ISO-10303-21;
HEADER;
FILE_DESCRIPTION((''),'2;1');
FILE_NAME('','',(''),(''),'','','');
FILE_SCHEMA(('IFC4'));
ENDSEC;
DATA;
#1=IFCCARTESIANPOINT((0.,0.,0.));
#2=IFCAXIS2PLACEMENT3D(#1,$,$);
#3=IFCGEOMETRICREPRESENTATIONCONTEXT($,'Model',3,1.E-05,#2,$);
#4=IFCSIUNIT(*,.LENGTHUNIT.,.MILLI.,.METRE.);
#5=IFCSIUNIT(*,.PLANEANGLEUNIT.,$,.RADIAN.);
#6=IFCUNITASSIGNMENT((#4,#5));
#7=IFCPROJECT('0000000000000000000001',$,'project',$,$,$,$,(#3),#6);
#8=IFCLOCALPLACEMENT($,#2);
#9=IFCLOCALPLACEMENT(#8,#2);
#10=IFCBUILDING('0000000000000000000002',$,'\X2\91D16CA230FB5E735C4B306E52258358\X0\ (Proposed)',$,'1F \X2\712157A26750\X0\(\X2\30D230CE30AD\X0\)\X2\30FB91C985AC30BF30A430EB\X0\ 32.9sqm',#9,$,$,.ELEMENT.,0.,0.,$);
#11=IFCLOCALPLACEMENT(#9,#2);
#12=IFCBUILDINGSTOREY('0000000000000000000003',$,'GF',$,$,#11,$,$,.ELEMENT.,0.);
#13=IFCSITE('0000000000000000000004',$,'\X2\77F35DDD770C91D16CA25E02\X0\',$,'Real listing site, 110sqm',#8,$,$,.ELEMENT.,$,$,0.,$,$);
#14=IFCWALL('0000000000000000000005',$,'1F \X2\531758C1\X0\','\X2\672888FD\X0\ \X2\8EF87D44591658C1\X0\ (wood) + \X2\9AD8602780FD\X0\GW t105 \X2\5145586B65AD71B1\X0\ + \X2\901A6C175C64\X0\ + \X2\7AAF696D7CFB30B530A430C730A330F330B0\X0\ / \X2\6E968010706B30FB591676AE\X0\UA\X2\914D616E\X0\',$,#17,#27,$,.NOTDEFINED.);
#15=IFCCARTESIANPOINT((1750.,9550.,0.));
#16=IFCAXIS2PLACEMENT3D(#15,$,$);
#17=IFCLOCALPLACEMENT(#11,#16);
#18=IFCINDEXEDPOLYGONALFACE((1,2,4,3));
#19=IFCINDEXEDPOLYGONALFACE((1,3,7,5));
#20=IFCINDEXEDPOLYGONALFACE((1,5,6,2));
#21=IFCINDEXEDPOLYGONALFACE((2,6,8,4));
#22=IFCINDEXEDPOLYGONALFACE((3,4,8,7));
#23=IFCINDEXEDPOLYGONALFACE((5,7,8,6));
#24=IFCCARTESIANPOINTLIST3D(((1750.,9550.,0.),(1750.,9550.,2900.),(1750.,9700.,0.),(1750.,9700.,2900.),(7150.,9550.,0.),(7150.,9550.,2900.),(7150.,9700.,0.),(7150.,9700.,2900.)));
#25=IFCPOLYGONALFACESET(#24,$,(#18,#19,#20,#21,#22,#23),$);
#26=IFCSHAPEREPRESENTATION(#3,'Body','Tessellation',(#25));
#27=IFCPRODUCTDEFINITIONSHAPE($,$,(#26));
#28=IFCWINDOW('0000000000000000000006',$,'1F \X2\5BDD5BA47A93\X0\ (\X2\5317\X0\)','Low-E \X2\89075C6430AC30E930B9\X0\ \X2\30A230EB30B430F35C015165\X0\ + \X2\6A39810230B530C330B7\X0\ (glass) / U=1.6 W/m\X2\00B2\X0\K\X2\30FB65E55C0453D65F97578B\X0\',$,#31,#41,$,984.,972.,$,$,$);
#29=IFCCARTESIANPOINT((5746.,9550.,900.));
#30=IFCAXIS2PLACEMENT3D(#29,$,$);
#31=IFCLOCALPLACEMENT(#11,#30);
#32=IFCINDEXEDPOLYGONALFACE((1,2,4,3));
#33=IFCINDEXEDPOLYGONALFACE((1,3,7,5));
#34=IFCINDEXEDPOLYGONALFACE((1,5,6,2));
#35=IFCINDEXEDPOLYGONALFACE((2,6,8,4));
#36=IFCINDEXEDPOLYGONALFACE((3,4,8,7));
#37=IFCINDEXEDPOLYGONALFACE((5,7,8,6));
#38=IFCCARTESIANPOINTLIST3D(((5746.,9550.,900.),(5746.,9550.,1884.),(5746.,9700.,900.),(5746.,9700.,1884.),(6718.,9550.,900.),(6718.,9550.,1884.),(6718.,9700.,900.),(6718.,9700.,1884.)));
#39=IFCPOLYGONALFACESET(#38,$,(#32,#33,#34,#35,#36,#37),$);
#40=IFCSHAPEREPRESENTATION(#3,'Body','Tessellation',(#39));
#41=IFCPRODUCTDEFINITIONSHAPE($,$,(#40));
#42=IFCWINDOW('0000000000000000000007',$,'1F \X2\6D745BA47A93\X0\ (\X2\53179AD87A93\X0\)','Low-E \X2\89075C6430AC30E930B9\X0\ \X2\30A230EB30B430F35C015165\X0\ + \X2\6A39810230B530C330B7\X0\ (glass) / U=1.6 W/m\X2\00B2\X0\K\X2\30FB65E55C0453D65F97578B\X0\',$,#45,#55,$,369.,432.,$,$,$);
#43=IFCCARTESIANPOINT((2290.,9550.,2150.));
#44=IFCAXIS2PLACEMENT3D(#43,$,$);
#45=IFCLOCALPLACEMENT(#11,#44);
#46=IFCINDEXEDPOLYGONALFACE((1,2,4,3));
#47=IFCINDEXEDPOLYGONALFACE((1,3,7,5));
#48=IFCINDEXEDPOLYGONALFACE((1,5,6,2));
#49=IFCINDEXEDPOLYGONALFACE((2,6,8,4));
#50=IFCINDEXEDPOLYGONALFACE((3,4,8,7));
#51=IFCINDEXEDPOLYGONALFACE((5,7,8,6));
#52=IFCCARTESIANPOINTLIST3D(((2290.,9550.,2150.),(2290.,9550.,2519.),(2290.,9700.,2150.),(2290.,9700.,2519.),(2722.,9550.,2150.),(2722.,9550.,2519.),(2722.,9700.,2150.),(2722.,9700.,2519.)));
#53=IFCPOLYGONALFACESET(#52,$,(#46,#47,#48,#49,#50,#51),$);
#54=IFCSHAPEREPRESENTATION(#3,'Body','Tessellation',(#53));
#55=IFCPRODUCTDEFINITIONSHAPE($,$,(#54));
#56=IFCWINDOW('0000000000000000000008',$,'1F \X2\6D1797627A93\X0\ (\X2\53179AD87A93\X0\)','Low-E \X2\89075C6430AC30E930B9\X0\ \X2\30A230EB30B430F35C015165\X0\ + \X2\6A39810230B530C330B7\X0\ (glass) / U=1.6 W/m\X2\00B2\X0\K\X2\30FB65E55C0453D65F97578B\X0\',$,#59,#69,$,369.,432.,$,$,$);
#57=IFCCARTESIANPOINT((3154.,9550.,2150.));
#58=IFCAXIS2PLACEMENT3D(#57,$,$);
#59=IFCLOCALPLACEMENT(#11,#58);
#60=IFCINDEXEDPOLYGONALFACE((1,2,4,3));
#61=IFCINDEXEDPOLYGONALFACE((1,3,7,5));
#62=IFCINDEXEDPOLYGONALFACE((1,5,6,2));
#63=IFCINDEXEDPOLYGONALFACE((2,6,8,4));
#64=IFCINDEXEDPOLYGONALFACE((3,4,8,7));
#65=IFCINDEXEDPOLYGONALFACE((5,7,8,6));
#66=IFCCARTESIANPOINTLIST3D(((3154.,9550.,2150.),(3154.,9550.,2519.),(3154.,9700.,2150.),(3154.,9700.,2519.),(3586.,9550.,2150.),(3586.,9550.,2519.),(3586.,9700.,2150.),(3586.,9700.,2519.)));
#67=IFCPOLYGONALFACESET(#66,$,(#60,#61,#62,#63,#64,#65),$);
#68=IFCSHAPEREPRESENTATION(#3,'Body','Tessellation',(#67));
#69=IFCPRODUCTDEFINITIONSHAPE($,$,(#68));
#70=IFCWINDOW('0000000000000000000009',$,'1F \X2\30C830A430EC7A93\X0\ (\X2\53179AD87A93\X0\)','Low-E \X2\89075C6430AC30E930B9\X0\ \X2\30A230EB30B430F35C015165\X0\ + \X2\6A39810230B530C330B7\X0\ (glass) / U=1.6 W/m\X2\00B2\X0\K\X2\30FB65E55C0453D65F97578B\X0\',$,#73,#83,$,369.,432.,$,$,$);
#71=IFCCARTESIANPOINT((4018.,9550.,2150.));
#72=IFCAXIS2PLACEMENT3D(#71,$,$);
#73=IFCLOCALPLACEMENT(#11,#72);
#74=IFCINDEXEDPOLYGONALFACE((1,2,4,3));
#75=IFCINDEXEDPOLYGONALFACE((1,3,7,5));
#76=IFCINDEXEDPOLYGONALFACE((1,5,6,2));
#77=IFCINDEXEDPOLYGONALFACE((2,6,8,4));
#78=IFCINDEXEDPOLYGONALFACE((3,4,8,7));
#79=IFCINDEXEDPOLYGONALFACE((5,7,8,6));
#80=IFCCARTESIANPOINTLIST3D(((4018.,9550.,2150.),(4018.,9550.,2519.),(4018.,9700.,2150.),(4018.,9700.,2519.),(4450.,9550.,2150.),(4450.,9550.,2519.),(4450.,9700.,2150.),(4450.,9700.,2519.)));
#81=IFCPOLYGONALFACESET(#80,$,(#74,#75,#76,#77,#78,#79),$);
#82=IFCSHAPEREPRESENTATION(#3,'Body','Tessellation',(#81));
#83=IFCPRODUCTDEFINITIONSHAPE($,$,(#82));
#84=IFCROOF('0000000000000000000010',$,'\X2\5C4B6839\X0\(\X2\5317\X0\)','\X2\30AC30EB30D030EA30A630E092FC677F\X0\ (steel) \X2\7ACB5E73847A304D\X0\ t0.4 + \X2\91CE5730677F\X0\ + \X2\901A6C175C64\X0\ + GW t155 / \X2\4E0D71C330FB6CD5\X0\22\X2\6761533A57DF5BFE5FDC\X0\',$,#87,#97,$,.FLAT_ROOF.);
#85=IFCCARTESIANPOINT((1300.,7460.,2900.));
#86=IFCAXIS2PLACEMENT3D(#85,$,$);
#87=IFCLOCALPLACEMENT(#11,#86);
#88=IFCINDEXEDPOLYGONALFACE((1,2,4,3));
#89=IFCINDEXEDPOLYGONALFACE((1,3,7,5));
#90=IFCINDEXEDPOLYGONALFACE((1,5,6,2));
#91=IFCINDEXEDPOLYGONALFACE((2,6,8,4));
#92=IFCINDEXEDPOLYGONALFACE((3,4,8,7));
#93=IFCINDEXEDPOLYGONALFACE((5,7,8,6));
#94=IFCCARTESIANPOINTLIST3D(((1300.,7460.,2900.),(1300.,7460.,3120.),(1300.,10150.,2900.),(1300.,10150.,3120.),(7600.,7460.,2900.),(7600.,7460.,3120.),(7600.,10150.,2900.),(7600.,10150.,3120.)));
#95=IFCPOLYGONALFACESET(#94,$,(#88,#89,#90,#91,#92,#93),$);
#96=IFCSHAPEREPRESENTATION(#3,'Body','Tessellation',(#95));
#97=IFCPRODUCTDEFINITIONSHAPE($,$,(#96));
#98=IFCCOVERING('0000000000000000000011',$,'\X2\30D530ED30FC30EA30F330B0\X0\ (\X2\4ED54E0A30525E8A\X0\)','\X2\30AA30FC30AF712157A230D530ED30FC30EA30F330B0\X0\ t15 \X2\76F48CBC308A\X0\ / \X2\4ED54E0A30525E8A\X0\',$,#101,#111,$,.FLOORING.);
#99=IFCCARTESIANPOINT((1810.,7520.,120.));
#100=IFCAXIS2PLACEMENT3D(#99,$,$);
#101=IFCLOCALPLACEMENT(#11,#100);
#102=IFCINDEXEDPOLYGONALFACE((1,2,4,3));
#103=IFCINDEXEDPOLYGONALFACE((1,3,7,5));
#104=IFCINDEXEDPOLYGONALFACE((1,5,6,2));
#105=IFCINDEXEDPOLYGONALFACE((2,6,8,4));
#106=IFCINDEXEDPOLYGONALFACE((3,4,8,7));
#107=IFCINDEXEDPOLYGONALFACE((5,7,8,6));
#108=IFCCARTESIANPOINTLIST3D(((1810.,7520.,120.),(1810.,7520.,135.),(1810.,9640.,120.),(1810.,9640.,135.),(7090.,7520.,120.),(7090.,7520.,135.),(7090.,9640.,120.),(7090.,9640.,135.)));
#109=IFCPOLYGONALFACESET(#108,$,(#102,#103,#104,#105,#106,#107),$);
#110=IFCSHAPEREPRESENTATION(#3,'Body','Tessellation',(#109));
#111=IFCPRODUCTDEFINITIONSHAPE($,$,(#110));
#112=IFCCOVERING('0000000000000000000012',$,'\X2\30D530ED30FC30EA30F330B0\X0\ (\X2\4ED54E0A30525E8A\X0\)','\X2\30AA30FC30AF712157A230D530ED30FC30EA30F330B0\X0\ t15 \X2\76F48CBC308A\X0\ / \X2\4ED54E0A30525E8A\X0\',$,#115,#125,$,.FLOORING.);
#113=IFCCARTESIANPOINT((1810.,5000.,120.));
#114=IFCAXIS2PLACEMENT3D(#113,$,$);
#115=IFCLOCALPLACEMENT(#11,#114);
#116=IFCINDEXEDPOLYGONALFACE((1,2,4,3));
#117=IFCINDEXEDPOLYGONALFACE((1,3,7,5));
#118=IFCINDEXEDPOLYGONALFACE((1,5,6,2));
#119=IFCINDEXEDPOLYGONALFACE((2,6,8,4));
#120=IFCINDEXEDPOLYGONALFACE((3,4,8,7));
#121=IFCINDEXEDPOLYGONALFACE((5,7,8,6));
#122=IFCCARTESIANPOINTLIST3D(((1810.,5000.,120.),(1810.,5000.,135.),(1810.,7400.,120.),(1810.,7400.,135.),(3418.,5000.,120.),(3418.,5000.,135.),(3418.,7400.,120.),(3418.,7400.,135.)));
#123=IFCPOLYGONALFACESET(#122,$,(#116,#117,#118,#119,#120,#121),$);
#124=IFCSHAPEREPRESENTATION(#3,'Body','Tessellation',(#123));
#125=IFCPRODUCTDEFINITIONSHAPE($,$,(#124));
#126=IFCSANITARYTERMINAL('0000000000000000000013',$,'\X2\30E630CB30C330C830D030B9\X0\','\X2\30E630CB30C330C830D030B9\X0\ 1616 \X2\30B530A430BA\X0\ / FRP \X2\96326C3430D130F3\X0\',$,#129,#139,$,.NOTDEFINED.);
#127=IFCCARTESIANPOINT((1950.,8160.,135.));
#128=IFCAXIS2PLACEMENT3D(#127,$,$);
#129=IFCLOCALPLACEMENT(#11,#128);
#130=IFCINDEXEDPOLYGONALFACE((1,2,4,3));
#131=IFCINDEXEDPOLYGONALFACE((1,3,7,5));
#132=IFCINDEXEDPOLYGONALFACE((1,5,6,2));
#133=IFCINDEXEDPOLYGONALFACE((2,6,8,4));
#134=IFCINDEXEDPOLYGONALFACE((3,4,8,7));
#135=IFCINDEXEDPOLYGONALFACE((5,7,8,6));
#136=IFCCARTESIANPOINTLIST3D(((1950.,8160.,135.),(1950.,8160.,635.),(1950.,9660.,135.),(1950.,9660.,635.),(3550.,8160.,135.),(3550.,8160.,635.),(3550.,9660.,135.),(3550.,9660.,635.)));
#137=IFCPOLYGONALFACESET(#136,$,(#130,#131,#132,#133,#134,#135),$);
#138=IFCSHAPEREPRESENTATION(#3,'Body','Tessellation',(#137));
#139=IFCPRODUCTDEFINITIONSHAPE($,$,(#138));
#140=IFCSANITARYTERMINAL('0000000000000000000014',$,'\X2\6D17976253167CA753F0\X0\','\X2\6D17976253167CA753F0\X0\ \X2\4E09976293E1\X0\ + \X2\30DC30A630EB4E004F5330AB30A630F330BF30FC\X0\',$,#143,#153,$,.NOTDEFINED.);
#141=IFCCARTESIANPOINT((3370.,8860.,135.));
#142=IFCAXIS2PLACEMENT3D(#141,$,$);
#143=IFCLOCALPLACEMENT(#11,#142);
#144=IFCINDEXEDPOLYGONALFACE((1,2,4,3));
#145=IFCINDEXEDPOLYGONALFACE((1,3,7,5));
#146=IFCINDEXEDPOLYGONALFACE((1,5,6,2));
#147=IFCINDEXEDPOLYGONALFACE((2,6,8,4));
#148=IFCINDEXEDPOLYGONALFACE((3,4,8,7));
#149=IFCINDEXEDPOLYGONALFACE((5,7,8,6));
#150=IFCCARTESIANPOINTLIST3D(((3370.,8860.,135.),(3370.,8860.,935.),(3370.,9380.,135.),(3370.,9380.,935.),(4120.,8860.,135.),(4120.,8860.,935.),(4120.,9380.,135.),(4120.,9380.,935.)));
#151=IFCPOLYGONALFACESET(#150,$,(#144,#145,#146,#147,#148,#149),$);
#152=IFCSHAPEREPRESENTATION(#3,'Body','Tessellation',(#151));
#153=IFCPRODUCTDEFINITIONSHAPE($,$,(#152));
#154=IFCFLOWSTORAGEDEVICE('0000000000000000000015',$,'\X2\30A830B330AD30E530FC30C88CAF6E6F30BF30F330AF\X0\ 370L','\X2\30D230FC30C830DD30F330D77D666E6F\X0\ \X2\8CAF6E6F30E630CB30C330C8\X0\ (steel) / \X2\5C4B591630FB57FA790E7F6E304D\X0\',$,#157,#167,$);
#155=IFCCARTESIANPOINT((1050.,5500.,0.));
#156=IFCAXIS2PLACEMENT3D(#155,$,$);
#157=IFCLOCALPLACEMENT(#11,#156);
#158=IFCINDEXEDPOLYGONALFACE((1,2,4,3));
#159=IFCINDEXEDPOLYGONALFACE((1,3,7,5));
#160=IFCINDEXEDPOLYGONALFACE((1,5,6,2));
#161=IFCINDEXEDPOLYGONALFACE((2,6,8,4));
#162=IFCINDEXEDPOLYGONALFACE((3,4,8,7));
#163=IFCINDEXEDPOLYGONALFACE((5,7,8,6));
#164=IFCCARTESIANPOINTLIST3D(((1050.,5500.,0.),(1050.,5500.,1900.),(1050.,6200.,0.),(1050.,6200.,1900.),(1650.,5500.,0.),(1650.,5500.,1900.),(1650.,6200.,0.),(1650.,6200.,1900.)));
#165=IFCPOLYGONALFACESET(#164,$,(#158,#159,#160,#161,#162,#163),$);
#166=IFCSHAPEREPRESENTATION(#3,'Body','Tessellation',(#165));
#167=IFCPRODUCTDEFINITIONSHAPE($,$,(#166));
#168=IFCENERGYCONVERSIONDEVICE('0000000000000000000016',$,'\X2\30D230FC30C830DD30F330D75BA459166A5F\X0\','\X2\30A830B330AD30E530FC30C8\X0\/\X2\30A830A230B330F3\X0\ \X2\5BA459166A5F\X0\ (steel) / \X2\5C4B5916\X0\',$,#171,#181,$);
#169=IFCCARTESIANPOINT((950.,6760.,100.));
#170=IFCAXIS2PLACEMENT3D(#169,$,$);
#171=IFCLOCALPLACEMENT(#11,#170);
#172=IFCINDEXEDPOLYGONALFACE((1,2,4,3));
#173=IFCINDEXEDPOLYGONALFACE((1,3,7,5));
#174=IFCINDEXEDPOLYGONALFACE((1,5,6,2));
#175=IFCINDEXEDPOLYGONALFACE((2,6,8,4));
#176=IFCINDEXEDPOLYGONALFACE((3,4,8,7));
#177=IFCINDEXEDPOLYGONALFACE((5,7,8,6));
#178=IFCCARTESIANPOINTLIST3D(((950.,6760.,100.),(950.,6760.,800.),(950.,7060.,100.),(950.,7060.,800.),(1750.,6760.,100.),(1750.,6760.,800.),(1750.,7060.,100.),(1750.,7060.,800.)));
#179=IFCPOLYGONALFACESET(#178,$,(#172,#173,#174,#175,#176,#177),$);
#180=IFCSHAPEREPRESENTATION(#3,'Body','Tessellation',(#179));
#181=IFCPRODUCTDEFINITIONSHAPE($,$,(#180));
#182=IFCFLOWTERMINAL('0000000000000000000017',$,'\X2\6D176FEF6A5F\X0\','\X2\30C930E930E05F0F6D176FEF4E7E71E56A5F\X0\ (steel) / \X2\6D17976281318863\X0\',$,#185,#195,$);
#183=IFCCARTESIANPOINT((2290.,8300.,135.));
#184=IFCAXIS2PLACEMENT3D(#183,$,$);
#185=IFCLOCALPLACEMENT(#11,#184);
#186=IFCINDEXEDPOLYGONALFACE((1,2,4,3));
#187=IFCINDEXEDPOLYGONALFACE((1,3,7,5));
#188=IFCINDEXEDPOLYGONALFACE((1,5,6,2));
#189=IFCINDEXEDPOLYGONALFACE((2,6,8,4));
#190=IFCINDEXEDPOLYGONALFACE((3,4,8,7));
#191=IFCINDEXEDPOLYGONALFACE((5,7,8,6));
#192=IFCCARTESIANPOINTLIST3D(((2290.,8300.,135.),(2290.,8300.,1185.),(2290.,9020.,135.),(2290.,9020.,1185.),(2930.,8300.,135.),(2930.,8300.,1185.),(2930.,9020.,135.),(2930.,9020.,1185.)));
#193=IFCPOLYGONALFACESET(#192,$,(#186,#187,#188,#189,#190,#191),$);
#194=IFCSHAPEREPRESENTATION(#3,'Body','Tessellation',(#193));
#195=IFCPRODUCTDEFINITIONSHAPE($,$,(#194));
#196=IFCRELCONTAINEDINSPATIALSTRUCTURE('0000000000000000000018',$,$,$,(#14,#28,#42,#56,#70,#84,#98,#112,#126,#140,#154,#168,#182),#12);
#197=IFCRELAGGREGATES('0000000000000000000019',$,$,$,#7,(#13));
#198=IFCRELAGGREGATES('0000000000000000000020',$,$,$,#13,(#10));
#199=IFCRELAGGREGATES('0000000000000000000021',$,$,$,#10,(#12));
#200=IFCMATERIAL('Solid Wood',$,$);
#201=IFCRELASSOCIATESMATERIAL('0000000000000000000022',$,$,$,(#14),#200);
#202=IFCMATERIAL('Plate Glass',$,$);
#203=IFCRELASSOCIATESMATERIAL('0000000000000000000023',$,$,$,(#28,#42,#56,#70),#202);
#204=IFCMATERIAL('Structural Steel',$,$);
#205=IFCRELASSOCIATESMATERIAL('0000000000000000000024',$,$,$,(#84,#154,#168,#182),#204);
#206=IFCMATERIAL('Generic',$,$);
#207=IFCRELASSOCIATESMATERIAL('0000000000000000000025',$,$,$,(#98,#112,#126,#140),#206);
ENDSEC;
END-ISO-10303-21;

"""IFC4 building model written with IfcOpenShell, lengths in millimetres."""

from ifc_helpers import new_model, si_unit, frame, frame_2d, origin, place, context, project, spatial, rectangle, extrude, material, element, fill, save


model = new_model("IFC4")

# Units and contexts
model_context = context("Model", 3, precision=1e-05, world=origin())
ifc_project = project(units=[si_unit("LENGTHUNIT", "METRE", prefix="MILLI"), si_unit("PLANEANGLEUNIT", "RADIAN")], contexts=[model_context])

# Site, building, storey
site_placement = place(None, origin())
site = spatial("IfcSite", under=ifc_project, at=site_placement, Name="石川県金沢市", ObjectType="Real listing site, 110sqm", CompositionType="ELEMENT", RefElevation=0.0)
building_placement = place(site_placement, origin())
building = spatial("IfcBuilding", under=site, at=building_placement, Name="金沢・平屋の別荘 (Proposed)", ObjectType="1F 無垢材(ヒノキ)・釉薬タイル 32.9sqm", CompositionType="ELEMENT", ElevationOfRefHeight=0.0, ElevationOfTerrain=0.0)
storey_placement = place(building_placement, origin())
storey = spatial("IfcBuildingStorey", under=building, at=storey_placement, Name="GF", CompositionType="ELEMENT", Elevation=0.0)

# Shared definitions
ifc_material_1 = material(Name="Solid Wood")

# Wall, openings, windows
wall_1_placement = place(storey_placement, frame((1750.0, 9550.0, 0.0)))
wall_1 = element("IfcWall", 1, at=wall_1_placement, inside=storey, material=ifc_material_1, Name="1F 北壁", Description="木製 軸組外壁 (wood) + 高性能GW t105 充填断熱 + 通気層 + 窯業系サイディング / 準耐火・外皮UA配慮", PredefinedType="NOTDEFINED", context=model_context, shape_type="SweptSolid", body=[
    extrude(rectangle(XDim=5400.0, YDim=150.0, at=frame_2d((2700.0, 75.0))), frame((1750.0, 9550.0, 0.0)), (0.0, 0.0, 1.0), 2900.0),
])
opening_1_placement = place(storey_placement, frame((5746.0, 9550.0, 900.0)))
opening_1 = element("IfcOpeningElement", 2, at=opening_1_placement, cuts=wall_1, PredefinedType="NOTDEFINED", context=model_context, shape_type="SweptSolid", body=[
    extrude(rectangle(XDim=972.0, YDim=150.0, at=frame_2d((486.0, 75.0))), frame((5746.0, 9550.0, 900.0)), (0.0, 0.0, 1.0), 984.0),
])
opening_2_placement = place(storey_placement, frame((2290.0, 9550.0, 2150.0)))
opening_2 = element("IfcOpeningElement", 3, at=opening_2_placement, cuts=wall_1, PredefinedType="NOTDEFINED", context=model_context, shape_type="SweptSolid", body=[
    extrude(rectangle(XDim=432.0, YDim=150.0, at=frame_2d((216.0, 75.0))), frame((2290.0, 9550.0, 2150.0)), (0.0, 0.0, 1.0), 369.0),
])
opening_3_placement = place(storey_placement, frame((3154.0, 9550.0, 2150.0)))
opening_3 = element("IfcOpeningElement", 4, at=opening_3_placement, cuts=wall_1, PredefinedType="NOTDEFINED", context=model_context, shape_type="SweptSolid", body=[
    extrude(rectangle(XDim=432.0, YDim=150.0, at=frame_2d((216.0, 75.0))), frame((3154.0, 9550.0, 2150.0)), (0.0, 0.0, 1.0), 369.0),
])
opening_4_placement = place(storey_placement, frame((4018.0, 9550.0, 2150.0)))
opening_4 = element("IfcOpeningElement", 5, at=opening_4_placement, cuts=wall_1, PredefinedType="NOTDEFINED", context=model_context, shape_type="SweptSolid", body=[
    extrude(rectangle(XDim=432.0, YDim=150.0, at=frame_2d((216.0, 75.0))), frame((4018.0, 9550.0, 2150.0)), (0.0, 0.0, 1.0), 369.0),
])
ifc_material_2 = material(Name="Plate Glass")
window_1_placement = place(storey_placement, frame((5746.0, 9550.0, 900.0)))
window_1 = element("IfcWindow", 6, at=window_1_placement, inside=storey, material=ifc_material_2, Name="1F 寝室窓 (北)", Description="Low-E 複層ガラス アルゴン封入 + 樹脂サッシ (glass) / U=1.6 W/m²K・日射取得型", OverallHeight=984.0, OverallWidth=972.0, context=model_context, shape_type="SweptSolid", body=[
    extrude(rectangle(XDim=972.0, YDim=150.0, at=frame_2d((486.0, 75.0))), frame((5746.0, 9550.0, 900.0)), (0.0, 0.0, 1.0), 984.0),
])
fill(opening_1, window_1)
window_2_placement = place(storey_placement, frame((2290.0, 9550.0, 2150.0)))
window_2 = element("IfcWindow", 7, at=window_2_placement, inside=storey, material=ifc_material_2, Name="1F 浴室窓 (北高窓)", Description="Low-E 複層ガラス アルゴン封入 + 樹脂サッシ (glass) / U=1.6 W/m²K・日射取得型", OverallHeight=369.0, OverallWidth=432.0, context=model_context, shape_type="SweptSolid", body=[
    extrude(rectangle(XDim=432.0, YDim=150.0, at=frame_2d((216.0, 75.0))), frame((2290.0, 9550.0, 2150.0)), (0.0, 0.0, 1.0), 369.0),
])
fill(opening_2, window_2)
window_3_placement = place(storey_placement, frame((3154.0, 9550.0, 2150.0)))
window_3 = element("IfcWindow", 8, at=window_3_placement, inside=storey, material=ifc_material_2, Name="1F 洗面窓 (北高窓)", Description="Low-E 複層ガラス アルゴン封入 + 樹脂サッシ (glass) / U=1.6 W/m²K・日射取得型", OverallHeight=369.0, OverallWidth=432.0, context=model_context, shape_type="SweptSolid", body=[
    extrude(rectangle(XDim=432.0, YDim=150.0, at=frame_2d((216.0, 75.0))), frame((3154.0, 9550.0, 2150.0)), (0.0, 0.0, 1.0), 369.0),
])
fill(opening_3, window_3)
window_4_placement = place(storey_placement, frame((4018.0, 9550.0, 2150.0)))
window_4 = element("IfcWindow", 9, at=window_4_placement, inside=storey, material=ifc_material_2, Name="1F トイレ窓 (北高窓)", Description="Low-E 複層ガラス アルゴン封入 + 樹脂サッシ (glass) / U=1.6 W/m²K・日射取得型", OverallHeight=369.0, OverallWidth=432.0, context=model_context, shape_type="SweptSolid", body=[
    extrude(rectangle(XDim=432.0, YDim=150.0, at=frame_2d((216.0, 75.0))), frame((4018.0, 9550.0, 2150.0)), (0.0, 0.0, 1.0), 369.0),
])
fill(opening_4, window_4)

# Roof
ifc_material_3 = material(Name="Structural Steel")
roof_placement = place(storey_placement, frame((1300.0, 7460.0, 2900.0)))
element("IfcRoof", 10, at=roof_placement, inside=storey, material=ifc_material_3, Name="屋根(北)", Description="ガルバリウム鋼板 (steel) 立平葺き t0.4 + 野地板 + 通気層 + GW t155 / 不燃・法22条区域対応", PredefinedType="FLAT_ROOF", context=model_context, shape_type="SweptSolid", body=[
    extrude(rectangle(XDim=6300.0, YDim=2690.0, at=frame_2d((3150.0, 1345.0))), frame((1300.0, 7460.0, 2900.0)), (0.0, 0.0, 1.0), 220.0),
])

# Coverings
ifc_material_4 = material(Name="Generic")
covering_1_placement = place(storey_placement, frame((1810.0, 7520.0, 120.0)))
element("IfcCovering", 11, at=covering_1_placement, inside=storey, material=ifc_material_4, Name="フローリング (仕上げ床)", Description="オーク無垢フローリング t15 直貼り / 仕上げ床", PredefinedType="FLOORING", context=model_context, shape_type="SweptSolid", body=[
    extrude(rectangle(XDim=5280.0, YDim=2120.0, at=frame_2d((2640.0, 1060.0))), frame((1810.0, 7520.0, 120.0)), (0.0, 0.0, 1.0), 15.0),
])
covering_2_placement = place(storey_placement, frame((1810.0, 5000.0, 120.0)))
element("IfcCovering", 12, at=covering_2_placement, inside=storey, material=ifc_material_4, Name="フローリング (仕上げ床)", Description="オーク無垢フローリング t15 直貼り / 仕上げ床", PredefinedType="FLOORING", context=model_context, shape_type="SweptSolid", body=[
    extrude(rectangle(XDim=1608.0, YDim=2400.0, at=frame_2d((804.0, 1200.0))), frame((1810.0, 5000.0, 120.0)), (0.0, 0.0, 1.0), 15.0),
])

# Sanitary terminals
sanitary_terminal_1_placement = place(storey_placement, frame((1950.0, 8160.0, 135.0)))
element("IfcSanitaryTerminal", 13, at=sanitary_terminal_1_placement, inside=storey, material=ifc_material_4, Name="ユニットバス", Description="ユニットバス 1616 サイズ / FRP 防水パン", PredefinedType="NOTDEFINED", context=model_context, shape_type="SweptSolid", body=[
    extrude(rectangle(XDim=1600.0, YDim=1500.0, at=frame_2d((800.0, 750.0))), frame((1950.0, 8160.0, 135.0)), (0.0, 0.0, 1.0), 500.0),
])
sanitary_terminal_2_placement = place(storey_placement, frame((3370.0, 8860.0, 135.0)))
element("IfcSanitaryTerminal", 14, at=sanitary_terminal_2_placement, inside=storey, material=ifc_material_4, Name="洗面化粧台", Description="洗面化粧台 三面鏡 + ボウル一体カウンター", PredefinedType="NOTDEFINED", context=model_context, shape_type="SweptSolid", body=[
    extrude(rectangle(XDim=750.0, YDim=520.0, at=frame_2d((375.0, 260.0))), frame((3370.0, 8860.0, 135.0)), (0.0, 0.0, 1.0), 800.0),
])

# Flow storage device
flow_storage_device_placement = place(storey_placement, frame((1050.0, 5500.0, 0.0)))
element("IfcFlowStorageDevice", 15, at=flow_storage_device_placement, inside=storey, material=ifc_material_3, Name="エコキュート貯湯タンク 370L", Description="ヒートポンプ給湯 貯湯ユニット (steel) / 屋外・基礎置き", context=model_context, shape_type="SweptSolid", body=[
    extrude(rectangle(XDim=600.0, YDim=700.0, at=frame_2d((300.0, 350.0))), frame((1050.0, 5500.0, 0.0)), (0.0, 0.0, 1.0), 1900.0),
])

# Energy conversion device
energy_conversion_device_placement = place(storey_placement, frame((950.0, 6760.0, 100.0)))
element("IfcEnergyConversionDevice", 16, at=energy_conversion_device_placement, inside=storey, material=ifc_material_3, Name="ヒートポンプ室外機", Description="エコキュート/エアコン 室外機 (steel) / 屋外", context=model_context, shape_type="SweptSolid", body=[
    extrude(rectangle(XDim=800.0, YDim=300.0, at=frame_2d((400.0, 150.0))), frame((950.0, 6760.0, 100.0)), (0.0, 0.0, 1.0), 700.0),
])

# Flow terminal
flow_terminal_placement = place(storey_placement, frame((2290.0, 8300.0, 135.0)))
element("IfcFlowTerminal", 17, at=flow_terminal_placement, inside=storey, material=ifc_material_3, Name="洗濯機", Description="ドラム式洗濯乾燥機 (steel) / 洗面脱衣", context=model_context, shape_type="SweptSolid", body=[
    extrude(rectangle(XDim=640.0, YDim=720.0, at=frame_2d((320.0, 360.0))), frame((2290.0, 8300.0, 135.0)), (0.0, 0.0, 1.0), 1050.0),
])

save(model, "model.ifc")
